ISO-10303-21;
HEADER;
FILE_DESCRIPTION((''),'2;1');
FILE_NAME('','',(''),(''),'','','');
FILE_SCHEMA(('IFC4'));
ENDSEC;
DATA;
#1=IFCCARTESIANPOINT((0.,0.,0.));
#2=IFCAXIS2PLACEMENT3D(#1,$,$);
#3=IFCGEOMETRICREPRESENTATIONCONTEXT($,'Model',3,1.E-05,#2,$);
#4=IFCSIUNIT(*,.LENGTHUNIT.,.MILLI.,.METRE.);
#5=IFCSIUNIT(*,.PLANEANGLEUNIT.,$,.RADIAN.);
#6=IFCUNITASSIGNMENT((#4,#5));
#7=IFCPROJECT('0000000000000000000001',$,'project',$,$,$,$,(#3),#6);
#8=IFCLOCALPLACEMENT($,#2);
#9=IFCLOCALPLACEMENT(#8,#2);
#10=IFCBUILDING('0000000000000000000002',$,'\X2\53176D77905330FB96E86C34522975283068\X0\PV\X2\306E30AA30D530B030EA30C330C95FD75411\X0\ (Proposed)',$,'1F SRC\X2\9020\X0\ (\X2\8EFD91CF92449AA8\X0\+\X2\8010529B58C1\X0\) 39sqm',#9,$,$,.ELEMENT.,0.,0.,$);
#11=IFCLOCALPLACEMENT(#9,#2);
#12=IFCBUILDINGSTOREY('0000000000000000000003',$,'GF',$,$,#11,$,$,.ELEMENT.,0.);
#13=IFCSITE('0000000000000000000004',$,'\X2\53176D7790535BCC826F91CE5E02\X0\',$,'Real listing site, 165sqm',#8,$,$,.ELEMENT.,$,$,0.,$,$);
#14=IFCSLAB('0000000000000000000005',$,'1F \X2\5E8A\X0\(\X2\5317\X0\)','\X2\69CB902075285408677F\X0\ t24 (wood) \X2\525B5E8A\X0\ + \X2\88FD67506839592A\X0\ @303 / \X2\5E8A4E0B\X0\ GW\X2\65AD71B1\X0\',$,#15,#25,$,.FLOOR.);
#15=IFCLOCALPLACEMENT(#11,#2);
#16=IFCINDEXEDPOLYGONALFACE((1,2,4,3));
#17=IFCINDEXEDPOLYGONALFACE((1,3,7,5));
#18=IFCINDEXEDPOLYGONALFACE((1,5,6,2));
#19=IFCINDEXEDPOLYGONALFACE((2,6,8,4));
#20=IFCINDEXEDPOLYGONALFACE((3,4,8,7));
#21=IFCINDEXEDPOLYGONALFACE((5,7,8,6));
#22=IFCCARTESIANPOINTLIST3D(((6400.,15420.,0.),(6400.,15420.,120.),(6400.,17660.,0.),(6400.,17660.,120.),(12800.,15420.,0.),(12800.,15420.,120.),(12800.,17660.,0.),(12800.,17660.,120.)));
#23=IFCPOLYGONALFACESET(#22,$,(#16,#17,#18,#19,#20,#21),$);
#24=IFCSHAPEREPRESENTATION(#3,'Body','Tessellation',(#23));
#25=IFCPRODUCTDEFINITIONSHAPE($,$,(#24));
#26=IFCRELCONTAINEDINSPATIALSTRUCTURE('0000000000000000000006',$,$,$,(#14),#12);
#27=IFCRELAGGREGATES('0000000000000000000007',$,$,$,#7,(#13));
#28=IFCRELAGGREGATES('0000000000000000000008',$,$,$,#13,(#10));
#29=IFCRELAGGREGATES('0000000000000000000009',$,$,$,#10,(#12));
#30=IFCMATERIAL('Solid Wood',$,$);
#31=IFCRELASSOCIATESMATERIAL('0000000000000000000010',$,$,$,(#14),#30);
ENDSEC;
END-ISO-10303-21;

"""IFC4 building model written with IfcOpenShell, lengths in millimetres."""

from ifc_helpers import new_model, si_unit, frame, frame_2d, origin, place, context, project, spatial, rectangle, extrude, material, element, save


model = new_model("IFC4")

# Units and contexts
model_context = context("Model", 3, precision=1e-05, world=origin())
ifc_project = project(units=[si_unit("LENGTHUNIT", "METRE", prefix="MILLI"), si_unit("PLANEANGLEUNIT", "RADIAN")], contexts=[model_context])

# Site, building, storey
site_placement = place(None, origin())
site = spatial("IfcSite", under=ifc_project, at=site_placement, Name="北海道富良野市", ObjectType="Real listing site, 165sqm", CompositionType="ELEMENT", RefElevation=0.0)
building_placement = place(site_placement, origin())
building = spatial("IfcBuilding", under=site, at=building_placement, Name="北海道・雨水利用とPVのオフグリッド志向 (Proposed)", ObjectType="1F SRC造 (軽量鉄骨+耐力壁) 39sqm", CompositionType="ELEMENT", ElevationOfRefHeight=0.0, ElevationOfTerrain=0.0)
storey_placement = place(building_placement, origin())
storey = spatial("IfcBuildingStorey", under=building, at=storey_placement, Name="GF", CompositionType="ELEMENT", Elevation=0.0)

# Shared definitions
ifc_material_1 = material(Name="Solid Wood")

# Slab
slab_1_placement = place(storey_placement, frame((3200.0, 7710.0, 0.0)))
element("IfcSlab", 1, at=slab_1_placement, inside=storey, material=ifc_material_1, Name="1F 床(北)", Description="構造用合板 t24 (wood) 剛床 + 製材根太 @303 / 床下 GW断熱", PredefinedType="FLOOR", context=model_context, shape_type="SweptSolid", body=[
    extrude(rectangle(XDim=6400.0, YDim=2240.0, at=frame_2d((3200.0, 1120.0))), frame((3200.0, 7710.0, 0.0)), (0.0, 0.0, 1.0), 120.0),
])

save(model, "model.ifc")
